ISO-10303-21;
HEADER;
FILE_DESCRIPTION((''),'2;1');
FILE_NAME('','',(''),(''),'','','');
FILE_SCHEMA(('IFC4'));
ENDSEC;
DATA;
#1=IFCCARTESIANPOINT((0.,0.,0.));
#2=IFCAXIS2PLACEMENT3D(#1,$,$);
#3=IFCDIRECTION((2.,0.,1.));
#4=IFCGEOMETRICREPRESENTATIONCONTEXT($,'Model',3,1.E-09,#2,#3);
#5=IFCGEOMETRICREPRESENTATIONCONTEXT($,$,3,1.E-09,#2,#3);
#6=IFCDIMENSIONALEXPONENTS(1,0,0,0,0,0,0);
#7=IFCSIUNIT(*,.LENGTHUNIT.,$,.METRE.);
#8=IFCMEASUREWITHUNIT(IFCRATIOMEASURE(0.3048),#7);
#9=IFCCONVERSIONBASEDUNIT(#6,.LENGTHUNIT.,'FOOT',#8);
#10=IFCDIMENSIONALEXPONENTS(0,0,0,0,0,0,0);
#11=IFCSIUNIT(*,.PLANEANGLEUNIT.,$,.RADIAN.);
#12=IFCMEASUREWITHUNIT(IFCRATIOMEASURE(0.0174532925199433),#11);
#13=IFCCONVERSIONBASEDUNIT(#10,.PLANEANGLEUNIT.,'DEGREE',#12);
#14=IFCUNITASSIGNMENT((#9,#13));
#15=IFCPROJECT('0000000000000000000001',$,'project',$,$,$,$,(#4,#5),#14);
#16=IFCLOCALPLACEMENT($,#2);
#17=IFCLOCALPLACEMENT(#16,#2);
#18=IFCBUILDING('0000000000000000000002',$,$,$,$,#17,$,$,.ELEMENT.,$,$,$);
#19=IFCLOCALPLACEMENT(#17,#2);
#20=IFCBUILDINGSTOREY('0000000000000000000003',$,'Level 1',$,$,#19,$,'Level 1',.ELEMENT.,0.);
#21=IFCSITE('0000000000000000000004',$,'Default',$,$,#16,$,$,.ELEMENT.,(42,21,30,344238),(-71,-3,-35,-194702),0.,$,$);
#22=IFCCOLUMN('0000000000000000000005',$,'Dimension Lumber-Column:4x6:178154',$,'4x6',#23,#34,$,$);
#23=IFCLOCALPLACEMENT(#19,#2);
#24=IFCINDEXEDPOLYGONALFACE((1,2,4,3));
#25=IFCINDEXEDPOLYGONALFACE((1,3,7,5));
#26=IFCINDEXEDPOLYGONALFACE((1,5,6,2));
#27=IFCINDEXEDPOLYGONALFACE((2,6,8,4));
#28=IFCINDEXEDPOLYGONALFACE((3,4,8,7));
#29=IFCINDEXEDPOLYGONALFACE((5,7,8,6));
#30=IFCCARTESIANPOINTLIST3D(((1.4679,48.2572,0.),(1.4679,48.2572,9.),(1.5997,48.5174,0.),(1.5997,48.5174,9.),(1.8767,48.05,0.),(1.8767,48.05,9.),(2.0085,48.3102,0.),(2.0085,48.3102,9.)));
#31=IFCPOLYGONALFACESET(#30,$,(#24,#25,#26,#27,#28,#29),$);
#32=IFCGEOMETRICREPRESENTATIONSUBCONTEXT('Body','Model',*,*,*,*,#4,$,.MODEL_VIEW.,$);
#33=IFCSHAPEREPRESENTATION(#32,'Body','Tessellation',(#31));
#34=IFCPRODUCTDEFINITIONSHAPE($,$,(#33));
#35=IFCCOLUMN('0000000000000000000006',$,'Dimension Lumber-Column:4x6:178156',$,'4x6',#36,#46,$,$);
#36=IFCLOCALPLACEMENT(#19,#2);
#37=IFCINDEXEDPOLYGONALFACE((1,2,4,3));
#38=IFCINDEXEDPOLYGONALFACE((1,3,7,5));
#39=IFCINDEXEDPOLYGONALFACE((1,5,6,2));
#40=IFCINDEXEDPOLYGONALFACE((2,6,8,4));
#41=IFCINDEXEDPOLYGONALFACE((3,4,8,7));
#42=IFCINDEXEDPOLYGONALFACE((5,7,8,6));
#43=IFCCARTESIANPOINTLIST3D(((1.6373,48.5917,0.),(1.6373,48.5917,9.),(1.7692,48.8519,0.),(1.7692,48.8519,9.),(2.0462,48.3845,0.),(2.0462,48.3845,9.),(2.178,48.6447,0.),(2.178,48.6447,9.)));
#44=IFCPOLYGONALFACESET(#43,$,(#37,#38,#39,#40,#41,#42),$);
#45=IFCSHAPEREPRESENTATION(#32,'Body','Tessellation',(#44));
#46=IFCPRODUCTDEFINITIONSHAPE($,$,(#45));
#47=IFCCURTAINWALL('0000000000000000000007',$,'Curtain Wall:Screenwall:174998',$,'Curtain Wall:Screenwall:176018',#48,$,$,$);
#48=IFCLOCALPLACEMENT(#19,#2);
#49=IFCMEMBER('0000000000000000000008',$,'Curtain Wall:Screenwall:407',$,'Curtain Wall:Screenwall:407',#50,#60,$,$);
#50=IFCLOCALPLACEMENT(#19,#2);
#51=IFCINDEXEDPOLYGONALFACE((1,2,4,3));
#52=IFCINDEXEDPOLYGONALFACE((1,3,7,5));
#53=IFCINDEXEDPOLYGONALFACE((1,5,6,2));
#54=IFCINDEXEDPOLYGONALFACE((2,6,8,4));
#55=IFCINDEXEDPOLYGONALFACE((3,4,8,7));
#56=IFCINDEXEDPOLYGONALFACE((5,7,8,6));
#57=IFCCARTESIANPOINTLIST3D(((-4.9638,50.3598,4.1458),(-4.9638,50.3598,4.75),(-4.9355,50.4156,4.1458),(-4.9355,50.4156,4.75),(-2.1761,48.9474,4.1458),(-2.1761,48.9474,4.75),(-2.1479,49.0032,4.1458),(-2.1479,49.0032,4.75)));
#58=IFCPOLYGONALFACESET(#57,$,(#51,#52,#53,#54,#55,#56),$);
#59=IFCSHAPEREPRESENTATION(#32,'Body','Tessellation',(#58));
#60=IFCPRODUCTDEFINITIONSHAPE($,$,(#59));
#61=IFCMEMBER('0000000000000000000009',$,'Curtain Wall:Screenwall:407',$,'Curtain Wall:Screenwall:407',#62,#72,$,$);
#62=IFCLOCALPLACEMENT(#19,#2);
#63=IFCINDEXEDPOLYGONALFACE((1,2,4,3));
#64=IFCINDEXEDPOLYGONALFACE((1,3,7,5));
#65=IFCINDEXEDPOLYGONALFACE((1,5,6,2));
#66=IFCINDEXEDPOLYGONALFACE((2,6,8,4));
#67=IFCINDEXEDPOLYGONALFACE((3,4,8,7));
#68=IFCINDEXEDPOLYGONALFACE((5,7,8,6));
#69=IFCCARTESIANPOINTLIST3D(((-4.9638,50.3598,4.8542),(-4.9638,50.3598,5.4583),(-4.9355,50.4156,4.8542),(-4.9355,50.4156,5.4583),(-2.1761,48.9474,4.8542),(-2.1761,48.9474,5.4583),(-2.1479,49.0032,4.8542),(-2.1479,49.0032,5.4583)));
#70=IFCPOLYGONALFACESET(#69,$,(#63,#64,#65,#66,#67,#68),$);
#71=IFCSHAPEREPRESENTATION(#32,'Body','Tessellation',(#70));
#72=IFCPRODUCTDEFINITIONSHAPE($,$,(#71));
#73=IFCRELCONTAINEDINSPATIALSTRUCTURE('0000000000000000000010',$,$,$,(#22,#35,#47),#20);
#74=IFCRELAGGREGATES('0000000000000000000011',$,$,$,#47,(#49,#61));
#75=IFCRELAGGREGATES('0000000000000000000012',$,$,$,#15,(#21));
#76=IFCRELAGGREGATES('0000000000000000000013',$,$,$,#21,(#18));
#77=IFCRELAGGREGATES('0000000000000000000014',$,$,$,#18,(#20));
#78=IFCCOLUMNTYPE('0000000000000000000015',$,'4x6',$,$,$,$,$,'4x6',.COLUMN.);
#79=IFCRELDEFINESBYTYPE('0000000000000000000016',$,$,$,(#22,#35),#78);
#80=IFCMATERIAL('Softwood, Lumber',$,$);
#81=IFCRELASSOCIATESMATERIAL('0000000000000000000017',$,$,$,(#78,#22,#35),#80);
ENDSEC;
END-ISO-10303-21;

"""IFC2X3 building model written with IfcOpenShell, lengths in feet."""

from ifc_helpers import new_model, entity, si_unit, converted_unit, direction, frame, frame_2d, origin, origin_2d_with_axis, place, context, subcontext, project, spatial, rectangle, extrude, source, transform, mapped, material, type_object, type_shapes, element, aggregate, save


model = new_model("IFC2X3")

# Units and contexts
model_context = context("Model", 3, precision=1e-09, world=origin(), true_north=direction((2.0, 0.0, 1.0)))
context_of_model = context(None, 3, precision=1e-09, world=origin(), true_north=direction((2.0, 0.0, 1.0)))
body_context = subcontext(model_context, "Body", "Model", "MODEL_VIEW")
ifc_project = project(units=[converted_unit("LENGTHUNIT", "FOOT", entity("IfcRatioMeasure", 0.3048), si_unit("LENGTHUNIT", "METRE"), dimensions=[1, 0, 0, 0, 0, 0, 0]), converted_unit("PLANEANGLEUNIT", "DEGREE", entity("IfcRatioMeasure", 0.0174532925199433), si_unit("PLANEANGLEUNIT", "RADIAN"), dimensions=[0, 0, 0, 0, 0, 0, 0])], contexts=[model_context, context_of_model])

# Site, building, storey
site_placement = place(None, origin())
site = spatial("IfcSite", under=ifc_project, at=site_placement, Name="Default", CompositionType="ELEMENT", RefLatitude=(42, 21, 30, 344238), RefLongitude=(-71, -3, -35, -194702), RefElevation=0.0)
building_placement = place(site_placement, origin())
building = spatial("IfcBuilding", under=site, at=building_placement, CompositionType="ELEMENT")
storey_placement = place(building_placement, origin())
storey = spatial("IfcBuildingStorey", under=building, at=storey_placement, Name="Level 1", LongName="Level 1", CompositionType="ELEMENT", Elevation=0.0)

# Columns
ifc_material = material(Name="Softwood, Lumber")
column_type = type_object("IfcColumnType", Name="4x6", ElementType="4x6", PredefinedType="COLUMN", material=ifc_material)
shared_shape = source(origin(), body_context, "Body", "SweptSolid", [
    extrude(rectangle(XDim=0.2917, YDim=0.4583, at=origin_2d_with_axis()), frame((0.0, 0.0, 0.0), z_axis=(0.0, 0.0, 1.0), x_axis=(-1.0, 0.0, 0.0)), (0.0, 0.0, 1.0), 9.0),
])
type_shapes(column_type, [shared_shape])
for number, where, z_axis, x_axis, name in (
    (1, (1.7382, 48.2837, 0.0), (0.0, 0.0, 1.0), (0.451968, 0.892034, 0.0), "Dimension Lumber-Column:4x6:178154"),
    (2, (1.9077, 48.6182, 0.0), (0.0, 0.0, 1.0), (0.451968, 0.892034, 0.0), "Dimension Lumber-Column:4x6:178156"),
):
    element("IfcColumn", number, at=place(storey_placement, frame(where, z_axis=z_axis, x_axis=x_axis)), inside=storey, type_object=column_type, material=ifc_material, Name=name, ObjectType="4x6", context=body_context, shape_type="MappedRepresentation", body=[
        mapped(shared_shape, transform((0.0, 0.0, 0.0), scale=1.0)),
    ])

# Curtain wall, members
curtain_wall_1_placement = place(storey_placement, origin())
curtain_wall_1 = element("IfcCurtainWall", 3, at=curtain_wall_1_placement, inside=storey, Name="Curtain Wall:Screenwall:174998", ObjectType="Curtain Wall:Screenwall:176018")
member_1_placement = place(curtain_wall_1_placement, frame((-4.9638, 48.9474, 4.1458)))
member_1 = element("IfcMember", 4, at=member_1_placement, Name="Curtain Wall:Screenwall:407", ObjectType="Curtain Wall:Screenwall:407", context=body_context, shape_type="SweptSolid", body=[
    extrude(rectangle(XDim=3.1251, YDim=0.0625, at=frame_2d((0.0, 0.0), x_axis=(1.0, 0.0))), frame((1.408, 0.7341, 0.0), z_axis=(0.0, 0.0, 1.0), x_axis=(0.892034, -0.451968, 0.0)), (0.0, 0.0, 1.0), 0.6042),
])
member_2_placement = place(curtain_wall_1_placement, frame((-4.9638, 48.9474, 4.8542)))
member_2 = element("IfcMember", 5, at=member_2_placement, Name="Curtain Wall:Screenwall:407", ObjectType="Curtain Wall:Screenwall:407", context=body_context, shape_type="SweptSolid", body=[
    extrude(rectangle(XDim=3.1251, YDim=0.0625, at=frame_2d((0.0, 0.0), x_axis=(1.0, 0.0))), frame((1.408, 0.7341, 0.0), z_axis=(0.0, 0.0, 1.0), x_axis=(0.892034, -0.451968, 0.0)), (0.0, 0.0, 1.0), 0.6042),
])
aggregate(curtain_wall_1, [member_1, member_2])

save(model, "model.ifc")
